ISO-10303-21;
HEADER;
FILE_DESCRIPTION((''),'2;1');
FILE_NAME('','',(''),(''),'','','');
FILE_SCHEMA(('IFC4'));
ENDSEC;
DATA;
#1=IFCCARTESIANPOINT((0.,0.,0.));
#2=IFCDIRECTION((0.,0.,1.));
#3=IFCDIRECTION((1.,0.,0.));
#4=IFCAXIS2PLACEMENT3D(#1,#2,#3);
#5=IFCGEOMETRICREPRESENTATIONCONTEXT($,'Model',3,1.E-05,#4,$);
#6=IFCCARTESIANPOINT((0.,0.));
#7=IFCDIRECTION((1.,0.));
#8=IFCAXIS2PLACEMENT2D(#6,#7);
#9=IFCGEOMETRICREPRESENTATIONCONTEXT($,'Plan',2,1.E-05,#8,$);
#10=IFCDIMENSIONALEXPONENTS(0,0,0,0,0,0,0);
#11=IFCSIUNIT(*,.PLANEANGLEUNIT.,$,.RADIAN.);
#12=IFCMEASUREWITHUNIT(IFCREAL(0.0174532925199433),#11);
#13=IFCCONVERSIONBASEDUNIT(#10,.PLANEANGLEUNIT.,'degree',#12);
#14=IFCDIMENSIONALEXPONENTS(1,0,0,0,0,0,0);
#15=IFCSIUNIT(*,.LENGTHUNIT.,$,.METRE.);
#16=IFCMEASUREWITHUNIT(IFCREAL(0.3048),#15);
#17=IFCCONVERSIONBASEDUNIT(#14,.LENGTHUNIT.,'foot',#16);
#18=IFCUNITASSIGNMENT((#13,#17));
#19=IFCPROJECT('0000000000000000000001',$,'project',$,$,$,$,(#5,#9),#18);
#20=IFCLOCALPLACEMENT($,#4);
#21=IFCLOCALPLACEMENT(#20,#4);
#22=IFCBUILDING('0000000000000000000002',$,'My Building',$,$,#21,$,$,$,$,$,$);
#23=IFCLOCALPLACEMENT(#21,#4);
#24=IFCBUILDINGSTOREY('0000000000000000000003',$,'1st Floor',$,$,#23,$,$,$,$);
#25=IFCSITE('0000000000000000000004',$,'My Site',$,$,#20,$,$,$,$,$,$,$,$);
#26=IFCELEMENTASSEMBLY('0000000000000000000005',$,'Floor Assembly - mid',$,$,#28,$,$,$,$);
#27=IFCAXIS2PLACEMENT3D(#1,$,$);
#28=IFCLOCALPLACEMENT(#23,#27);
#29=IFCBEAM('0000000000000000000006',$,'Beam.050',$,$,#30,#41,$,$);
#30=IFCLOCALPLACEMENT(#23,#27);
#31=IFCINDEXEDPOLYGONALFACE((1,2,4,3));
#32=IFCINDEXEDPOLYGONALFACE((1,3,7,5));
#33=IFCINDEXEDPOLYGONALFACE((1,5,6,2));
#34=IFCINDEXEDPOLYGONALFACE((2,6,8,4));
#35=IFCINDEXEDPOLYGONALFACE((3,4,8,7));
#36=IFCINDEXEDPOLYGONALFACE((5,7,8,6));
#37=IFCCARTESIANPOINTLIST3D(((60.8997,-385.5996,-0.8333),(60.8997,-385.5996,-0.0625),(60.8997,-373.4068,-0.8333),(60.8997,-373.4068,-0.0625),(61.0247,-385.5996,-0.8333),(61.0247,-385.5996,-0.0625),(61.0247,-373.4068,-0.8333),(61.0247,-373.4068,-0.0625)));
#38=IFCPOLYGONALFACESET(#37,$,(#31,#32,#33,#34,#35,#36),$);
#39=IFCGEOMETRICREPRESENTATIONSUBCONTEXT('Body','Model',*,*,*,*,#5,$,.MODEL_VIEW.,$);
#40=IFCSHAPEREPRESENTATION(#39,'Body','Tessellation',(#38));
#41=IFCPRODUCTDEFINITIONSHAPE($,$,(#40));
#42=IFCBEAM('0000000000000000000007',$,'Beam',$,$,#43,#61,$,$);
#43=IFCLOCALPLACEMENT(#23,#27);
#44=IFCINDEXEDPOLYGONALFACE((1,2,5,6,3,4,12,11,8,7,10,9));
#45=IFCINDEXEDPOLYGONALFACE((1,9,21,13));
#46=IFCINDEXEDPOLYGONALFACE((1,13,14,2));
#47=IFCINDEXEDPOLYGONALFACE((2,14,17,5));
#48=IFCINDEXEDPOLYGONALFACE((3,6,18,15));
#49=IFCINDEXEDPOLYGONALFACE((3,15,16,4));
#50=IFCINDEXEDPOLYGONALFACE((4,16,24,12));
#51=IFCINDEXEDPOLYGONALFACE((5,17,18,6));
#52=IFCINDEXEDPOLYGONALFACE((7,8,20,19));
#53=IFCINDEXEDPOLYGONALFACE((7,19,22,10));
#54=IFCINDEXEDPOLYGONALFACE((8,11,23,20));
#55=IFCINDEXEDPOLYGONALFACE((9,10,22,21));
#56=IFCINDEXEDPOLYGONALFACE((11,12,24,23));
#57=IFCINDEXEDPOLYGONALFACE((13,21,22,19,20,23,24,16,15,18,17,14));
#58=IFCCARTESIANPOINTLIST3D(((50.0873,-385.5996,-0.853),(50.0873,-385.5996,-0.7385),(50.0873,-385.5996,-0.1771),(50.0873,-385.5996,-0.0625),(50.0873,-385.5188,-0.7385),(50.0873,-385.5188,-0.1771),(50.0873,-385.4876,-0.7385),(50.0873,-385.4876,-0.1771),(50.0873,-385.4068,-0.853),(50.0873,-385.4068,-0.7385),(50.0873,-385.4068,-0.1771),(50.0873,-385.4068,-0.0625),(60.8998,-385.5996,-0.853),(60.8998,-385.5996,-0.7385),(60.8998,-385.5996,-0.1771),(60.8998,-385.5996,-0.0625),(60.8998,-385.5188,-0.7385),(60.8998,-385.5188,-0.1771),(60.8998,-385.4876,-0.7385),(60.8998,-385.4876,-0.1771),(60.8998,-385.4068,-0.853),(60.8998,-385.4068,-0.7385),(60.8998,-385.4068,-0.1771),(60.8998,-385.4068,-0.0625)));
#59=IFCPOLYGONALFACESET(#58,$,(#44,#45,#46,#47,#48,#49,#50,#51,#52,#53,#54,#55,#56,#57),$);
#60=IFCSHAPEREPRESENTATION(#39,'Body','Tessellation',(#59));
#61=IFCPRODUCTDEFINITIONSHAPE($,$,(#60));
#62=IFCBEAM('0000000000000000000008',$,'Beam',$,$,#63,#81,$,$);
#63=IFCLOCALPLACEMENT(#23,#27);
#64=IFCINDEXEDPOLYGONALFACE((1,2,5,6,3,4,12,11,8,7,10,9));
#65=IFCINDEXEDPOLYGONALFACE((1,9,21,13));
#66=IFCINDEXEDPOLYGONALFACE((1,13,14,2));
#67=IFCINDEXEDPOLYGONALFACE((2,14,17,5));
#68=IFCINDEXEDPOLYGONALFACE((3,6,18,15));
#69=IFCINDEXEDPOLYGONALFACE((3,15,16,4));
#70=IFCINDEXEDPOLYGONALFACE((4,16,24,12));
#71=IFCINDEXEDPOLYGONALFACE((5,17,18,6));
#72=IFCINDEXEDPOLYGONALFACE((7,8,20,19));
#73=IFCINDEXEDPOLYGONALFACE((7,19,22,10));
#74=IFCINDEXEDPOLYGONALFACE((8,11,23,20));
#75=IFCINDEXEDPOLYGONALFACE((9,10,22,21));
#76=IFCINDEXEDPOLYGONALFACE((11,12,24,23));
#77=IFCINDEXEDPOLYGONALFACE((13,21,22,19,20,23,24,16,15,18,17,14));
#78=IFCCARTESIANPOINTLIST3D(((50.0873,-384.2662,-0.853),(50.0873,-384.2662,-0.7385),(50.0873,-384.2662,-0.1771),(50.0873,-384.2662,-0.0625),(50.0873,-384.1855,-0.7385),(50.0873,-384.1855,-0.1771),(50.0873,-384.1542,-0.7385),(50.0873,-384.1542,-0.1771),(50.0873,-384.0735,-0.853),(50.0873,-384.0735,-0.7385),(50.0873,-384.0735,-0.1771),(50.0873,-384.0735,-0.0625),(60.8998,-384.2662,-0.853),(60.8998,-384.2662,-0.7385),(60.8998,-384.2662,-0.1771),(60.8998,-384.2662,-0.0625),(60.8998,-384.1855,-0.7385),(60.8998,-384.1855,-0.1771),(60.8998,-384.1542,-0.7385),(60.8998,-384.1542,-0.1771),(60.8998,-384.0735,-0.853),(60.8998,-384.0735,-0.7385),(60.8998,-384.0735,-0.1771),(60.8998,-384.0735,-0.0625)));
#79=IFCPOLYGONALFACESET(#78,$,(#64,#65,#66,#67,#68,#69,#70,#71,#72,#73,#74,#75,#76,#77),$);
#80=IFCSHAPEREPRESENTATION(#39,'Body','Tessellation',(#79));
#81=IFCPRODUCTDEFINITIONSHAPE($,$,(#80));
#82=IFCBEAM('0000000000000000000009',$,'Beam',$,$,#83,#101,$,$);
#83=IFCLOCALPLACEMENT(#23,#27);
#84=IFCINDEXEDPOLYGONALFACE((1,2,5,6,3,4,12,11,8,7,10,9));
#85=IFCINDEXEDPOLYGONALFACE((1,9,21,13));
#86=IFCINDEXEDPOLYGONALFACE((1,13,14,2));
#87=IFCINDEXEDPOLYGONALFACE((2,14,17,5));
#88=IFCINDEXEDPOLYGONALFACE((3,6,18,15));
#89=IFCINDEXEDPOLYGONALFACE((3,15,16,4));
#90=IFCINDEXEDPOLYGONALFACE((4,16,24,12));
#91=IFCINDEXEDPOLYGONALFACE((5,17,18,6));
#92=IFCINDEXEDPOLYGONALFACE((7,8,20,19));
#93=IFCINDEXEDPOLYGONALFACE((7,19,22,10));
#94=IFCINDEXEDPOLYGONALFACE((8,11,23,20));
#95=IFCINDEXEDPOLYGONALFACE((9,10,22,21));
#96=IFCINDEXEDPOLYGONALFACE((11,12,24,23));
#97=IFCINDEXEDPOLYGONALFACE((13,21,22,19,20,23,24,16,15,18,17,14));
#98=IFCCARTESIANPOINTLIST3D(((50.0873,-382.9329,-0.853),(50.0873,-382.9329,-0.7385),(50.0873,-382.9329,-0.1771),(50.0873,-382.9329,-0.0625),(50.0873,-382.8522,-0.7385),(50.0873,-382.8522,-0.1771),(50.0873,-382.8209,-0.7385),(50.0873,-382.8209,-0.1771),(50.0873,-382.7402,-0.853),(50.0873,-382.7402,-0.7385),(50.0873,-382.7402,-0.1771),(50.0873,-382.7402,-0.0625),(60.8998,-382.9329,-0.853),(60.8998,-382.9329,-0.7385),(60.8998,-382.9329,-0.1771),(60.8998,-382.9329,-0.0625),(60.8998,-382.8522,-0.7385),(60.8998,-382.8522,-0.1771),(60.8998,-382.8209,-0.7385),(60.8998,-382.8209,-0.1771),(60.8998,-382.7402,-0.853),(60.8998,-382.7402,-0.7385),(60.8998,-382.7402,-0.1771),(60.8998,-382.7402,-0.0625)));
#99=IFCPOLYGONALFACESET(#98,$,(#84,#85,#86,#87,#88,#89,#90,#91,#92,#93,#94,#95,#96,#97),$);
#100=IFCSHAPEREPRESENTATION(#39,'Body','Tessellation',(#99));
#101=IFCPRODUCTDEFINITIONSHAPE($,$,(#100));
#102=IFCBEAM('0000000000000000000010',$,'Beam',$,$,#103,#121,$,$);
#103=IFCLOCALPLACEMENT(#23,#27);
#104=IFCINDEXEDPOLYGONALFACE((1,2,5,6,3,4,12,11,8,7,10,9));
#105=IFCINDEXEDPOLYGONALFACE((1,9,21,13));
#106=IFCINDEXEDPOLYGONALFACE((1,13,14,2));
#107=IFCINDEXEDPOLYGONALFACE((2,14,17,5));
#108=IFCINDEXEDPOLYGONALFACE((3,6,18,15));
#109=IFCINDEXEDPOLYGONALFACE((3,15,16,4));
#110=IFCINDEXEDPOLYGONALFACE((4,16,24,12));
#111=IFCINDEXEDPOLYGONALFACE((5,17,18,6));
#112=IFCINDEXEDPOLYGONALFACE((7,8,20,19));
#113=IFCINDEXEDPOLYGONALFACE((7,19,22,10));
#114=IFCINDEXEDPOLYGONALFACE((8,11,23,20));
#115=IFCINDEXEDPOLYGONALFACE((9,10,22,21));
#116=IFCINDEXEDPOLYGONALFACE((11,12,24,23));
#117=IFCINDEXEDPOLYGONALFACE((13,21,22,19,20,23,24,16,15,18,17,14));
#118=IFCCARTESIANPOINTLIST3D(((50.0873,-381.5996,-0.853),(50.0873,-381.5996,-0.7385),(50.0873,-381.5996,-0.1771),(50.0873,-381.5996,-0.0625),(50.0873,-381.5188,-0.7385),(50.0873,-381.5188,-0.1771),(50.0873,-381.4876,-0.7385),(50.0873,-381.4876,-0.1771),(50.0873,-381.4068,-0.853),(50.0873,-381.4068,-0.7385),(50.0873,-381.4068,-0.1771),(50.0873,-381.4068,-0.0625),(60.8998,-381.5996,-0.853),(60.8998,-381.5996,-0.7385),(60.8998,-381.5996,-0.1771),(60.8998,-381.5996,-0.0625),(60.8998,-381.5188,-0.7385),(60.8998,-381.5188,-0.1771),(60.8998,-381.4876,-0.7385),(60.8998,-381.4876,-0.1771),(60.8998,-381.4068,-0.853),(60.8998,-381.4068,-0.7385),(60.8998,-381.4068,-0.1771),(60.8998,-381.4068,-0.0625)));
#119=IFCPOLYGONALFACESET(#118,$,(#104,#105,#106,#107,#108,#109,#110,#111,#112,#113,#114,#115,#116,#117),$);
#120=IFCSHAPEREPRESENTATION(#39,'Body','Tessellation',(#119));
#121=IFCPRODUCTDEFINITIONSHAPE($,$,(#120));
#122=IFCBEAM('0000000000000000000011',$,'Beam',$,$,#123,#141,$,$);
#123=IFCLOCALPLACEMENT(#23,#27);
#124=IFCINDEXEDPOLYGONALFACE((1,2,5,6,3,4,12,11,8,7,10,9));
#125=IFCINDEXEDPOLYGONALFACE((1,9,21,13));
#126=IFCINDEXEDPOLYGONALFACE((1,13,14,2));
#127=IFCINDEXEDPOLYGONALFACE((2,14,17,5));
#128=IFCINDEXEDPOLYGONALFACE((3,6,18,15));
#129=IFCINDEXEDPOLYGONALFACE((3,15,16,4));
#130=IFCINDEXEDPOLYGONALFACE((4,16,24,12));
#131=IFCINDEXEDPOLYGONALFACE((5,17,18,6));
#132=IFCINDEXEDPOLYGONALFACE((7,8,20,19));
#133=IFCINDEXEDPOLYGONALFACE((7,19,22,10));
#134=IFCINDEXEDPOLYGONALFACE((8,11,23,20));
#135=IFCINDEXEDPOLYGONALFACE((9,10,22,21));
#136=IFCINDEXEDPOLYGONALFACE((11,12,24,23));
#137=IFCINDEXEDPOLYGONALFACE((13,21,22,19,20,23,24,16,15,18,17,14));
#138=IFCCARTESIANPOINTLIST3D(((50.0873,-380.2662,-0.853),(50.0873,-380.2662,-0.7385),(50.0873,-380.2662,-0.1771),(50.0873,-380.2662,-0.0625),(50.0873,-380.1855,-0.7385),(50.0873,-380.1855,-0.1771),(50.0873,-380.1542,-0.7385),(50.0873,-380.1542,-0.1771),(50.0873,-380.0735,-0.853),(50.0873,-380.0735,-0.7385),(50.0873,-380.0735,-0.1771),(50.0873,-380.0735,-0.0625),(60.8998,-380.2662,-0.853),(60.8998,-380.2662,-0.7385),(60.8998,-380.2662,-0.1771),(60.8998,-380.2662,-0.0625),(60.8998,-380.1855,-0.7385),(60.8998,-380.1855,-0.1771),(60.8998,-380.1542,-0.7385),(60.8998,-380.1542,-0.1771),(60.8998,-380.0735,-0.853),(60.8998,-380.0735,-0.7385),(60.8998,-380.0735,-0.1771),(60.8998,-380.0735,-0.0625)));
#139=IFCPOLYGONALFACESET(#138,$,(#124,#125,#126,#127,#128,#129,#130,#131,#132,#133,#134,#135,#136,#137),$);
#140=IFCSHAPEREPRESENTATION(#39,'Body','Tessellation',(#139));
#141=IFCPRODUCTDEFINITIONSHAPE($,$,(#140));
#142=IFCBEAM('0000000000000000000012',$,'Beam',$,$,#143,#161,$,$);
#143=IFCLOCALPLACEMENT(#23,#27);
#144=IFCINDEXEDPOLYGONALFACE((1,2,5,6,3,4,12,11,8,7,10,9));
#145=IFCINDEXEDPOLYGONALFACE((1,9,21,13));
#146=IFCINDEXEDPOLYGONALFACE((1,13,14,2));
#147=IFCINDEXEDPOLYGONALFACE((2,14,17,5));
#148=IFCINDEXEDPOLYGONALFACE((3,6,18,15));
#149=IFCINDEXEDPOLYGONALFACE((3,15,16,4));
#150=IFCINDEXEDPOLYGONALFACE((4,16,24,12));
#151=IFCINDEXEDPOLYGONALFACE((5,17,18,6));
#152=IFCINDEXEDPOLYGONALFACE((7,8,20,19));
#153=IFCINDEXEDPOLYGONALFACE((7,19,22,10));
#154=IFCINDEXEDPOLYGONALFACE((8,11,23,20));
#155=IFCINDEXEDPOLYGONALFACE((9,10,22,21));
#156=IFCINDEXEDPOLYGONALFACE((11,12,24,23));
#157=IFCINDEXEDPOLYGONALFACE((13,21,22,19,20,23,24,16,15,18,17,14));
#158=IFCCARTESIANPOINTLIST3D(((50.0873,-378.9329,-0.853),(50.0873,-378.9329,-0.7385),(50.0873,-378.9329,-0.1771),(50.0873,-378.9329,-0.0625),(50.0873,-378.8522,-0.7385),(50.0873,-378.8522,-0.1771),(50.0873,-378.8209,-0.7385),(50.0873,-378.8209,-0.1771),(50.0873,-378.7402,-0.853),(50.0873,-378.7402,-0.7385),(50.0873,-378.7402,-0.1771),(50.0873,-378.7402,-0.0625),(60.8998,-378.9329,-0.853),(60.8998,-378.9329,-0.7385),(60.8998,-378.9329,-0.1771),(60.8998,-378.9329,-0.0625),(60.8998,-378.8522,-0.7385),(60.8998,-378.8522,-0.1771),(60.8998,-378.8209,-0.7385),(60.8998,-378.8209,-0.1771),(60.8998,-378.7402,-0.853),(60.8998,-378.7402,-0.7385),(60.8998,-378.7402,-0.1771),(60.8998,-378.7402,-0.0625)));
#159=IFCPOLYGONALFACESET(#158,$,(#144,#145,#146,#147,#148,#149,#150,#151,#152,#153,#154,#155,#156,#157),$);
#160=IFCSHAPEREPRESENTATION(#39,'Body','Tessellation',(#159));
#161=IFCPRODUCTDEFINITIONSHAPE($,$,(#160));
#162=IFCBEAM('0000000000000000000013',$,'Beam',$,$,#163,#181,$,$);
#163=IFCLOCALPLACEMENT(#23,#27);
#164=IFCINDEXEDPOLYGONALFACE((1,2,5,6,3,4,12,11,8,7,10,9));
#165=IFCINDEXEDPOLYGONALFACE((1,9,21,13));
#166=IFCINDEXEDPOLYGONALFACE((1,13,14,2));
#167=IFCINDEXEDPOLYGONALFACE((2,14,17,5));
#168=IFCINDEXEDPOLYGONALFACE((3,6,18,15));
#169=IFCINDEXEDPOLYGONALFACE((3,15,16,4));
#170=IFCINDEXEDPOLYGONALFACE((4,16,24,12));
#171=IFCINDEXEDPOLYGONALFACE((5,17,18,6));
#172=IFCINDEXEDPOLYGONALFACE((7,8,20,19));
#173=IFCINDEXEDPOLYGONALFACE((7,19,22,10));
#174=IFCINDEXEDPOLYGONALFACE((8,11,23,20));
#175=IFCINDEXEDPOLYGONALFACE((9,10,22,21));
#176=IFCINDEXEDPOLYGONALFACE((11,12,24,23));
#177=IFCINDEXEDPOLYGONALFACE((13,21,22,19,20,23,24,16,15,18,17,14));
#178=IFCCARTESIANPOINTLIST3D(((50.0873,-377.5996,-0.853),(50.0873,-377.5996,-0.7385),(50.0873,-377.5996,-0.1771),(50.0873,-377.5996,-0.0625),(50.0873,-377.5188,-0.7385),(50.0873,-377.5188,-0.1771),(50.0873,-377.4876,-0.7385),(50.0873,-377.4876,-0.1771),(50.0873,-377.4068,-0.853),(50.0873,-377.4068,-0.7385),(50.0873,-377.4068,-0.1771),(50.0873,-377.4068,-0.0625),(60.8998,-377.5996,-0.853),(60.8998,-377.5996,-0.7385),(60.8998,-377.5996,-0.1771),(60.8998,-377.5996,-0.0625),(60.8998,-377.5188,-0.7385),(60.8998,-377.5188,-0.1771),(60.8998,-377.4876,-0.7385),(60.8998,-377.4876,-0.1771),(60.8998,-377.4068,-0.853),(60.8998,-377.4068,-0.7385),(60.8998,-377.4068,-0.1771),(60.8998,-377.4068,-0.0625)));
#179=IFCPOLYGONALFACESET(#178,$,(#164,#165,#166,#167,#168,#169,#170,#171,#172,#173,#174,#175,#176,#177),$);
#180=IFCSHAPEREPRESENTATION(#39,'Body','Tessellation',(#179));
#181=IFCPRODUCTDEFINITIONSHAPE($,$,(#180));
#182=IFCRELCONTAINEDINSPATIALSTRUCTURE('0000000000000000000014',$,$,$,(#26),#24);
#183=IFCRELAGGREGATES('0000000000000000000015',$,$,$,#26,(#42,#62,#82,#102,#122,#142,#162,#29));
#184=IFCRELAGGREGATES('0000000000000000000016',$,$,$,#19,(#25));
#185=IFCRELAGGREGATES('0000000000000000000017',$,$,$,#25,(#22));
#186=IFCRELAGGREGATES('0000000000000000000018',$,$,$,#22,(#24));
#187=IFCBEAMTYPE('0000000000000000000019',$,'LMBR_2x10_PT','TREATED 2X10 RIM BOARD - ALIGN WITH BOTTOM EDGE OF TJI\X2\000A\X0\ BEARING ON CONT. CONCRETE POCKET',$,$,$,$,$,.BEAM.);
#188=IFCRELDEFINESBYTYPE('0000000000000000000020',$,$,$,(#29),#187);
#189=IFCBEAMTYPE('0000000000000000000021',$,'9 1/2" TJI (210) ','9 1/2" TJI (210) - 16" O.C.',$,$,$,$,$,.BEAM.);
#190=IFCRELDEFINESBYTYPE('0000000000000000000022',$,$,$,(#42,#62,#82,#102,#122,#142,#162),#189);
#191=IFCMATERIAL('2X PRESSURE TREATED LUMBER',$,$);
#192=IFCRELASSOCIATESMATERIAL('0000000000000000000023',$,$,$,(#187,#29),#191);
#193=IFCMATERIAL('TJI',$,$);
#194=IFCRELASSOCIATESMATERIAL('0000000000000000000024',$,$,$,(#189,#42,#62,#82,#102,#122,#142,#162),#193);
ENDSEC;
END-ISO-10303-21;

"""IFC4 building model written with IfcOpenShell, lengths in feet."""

from ifc_helpers import new_model, entity, si_unit, converted_unit, frame, origin_with_axes, origin_2d_with_axis, place, context, subcontext, project, spatial, indexed_curve, outline, extrude, material, material_profile, profile_set, profile_usage, type_object, element, aggregate, save


model = new_model("IFC4")

# Units and contexts
model_context = context("Model", 3, precision=1e-05, world=origin_with_axes())
plan_context = context("Plan", 2, precision=1e-05, world=origin_2d_with_axis())
body_context = subcontext(model_context, "Body", "Model", "MODEL_VIEW")
ifc_project = project(units=[converted_unit("PLANEANGLEUNIT", "degree", entity("IfcReal", 0.0174532925199433), si_unit("PLANEANGLEUNIT", "RADIAN"), dimensions=[0, 0, 0, 0, 0, 0, 0]), converted_unit("LENGTHUNIT", "foot", entity("IfcReal", 0.3048), si_unit("LENGTHUNIT", "METRE"), dimensions=[1, 0, 0, 0, 0, 0, 0])], contexts=[model_context, plan_context])

# Site, building, storey
site_placement = place(None, origin_with_axes())
site = spatial("IfcSite", under=ifc_project, at=site_placement, Name="My Site")
building_placement = place(site_placement, origin_with_axes())
building = spatial("IfcBuilding", under=site, at=building_placement, Name="My Building")
storey_placement = place(building_placement, origin_with_axes())
storey = spatial("IfcBuildingStorey", under=building, at=storey_placement, Name="1st Floor")

# Element assembly, beams
assembly_1_placement = place(storey_placement, frame((50.0352, -373.4068, -0.0625), z_axis=(0.0, 0.0, 1.0), x_axis=(1.0, 0.0, 0.0)))
assembly_1 = element("IfcElementAssembly", 1, at=assembly_1_placement, inside=storey, Name="Floor Assembly - mid")
ifc_material_1 = material(Name="2X PRESSURE TREATED LUMBER")
ifc_material_profile_1 = material_profile(ifc_material_1, outline(indexed_curve([(-0.0625, 0.3854), (0.0625, 0.3854), (0.0625, -0.3854), (-0.0625, -0.3854), (-0.0625, 0.3854)])))
ifc_profile_set_1 = profile_set([ifc_material_profile_1])
ifc_profile_usage_1 = profile_usage(ifc_profile_set_1, cardinal=5)
beam_type_1 = type_object("IfcBeamType", Name="LMBR_2x10_PT", Description="TREATED 2X10 RIM BOARD - ALIGN WITH BOTTOM EDGE OF TJI\n BEARING ON CONT. CONCRETE POCKET", PredefinedType="BEAM", material=ifc_profile_set_1)
beam_1_placement = place(assembly_1_placement, frame((10.927, 0.0, -0.3854), z_axis=(0.000001, -1.0, 0.0), x_axis=(1.0, 0.000001, 0.0)))
beam_1 = element("IfcBeam", 2, at=beam_1_placement, type_object=beam_type_1, material=ifc_profile_usage_1, Name="Beam.050", context=body_context, shape_type="SweptSolid", body=[
    extrude(outline(indexed_curve([(-0.0625, 0.3854), (0.0625, 0.3854), (0.0625, -0.3854), (-0.0625, -0.3854), (-0.0625, 0.3854)])), origin_with_axes(), (0.0, 0.0, 1.0), 12.1927),
])
ifc_material_2 = material(Name="TJI")
ifc_material_profile_2 = material_profile(ifc_material_2, outline(indexed_curve([(0.0964, 0.7905), (-0.0964, 0.7905), (-0.0964, 0.6759), (-0.0156, 0.6759), (-0.0156, 0.1146), (-0.0964, 0.1146), (-0.0964, 0.0), (0.0964, 0.0), (0.0964, 0.1146), (0.0156, 0.1146), (0.0157, 0.6759), (0.0964, 0.6759), (0.0964, 0.7905)])))
ifc_profile_set_2 = profile_set([ifc_material_profile_2])
ifc_profile_usage_2 = profile_usage(ifc_profile_set_2, cardinal=5)
beam_type_2 = type_object("IfcBeamType", Name="9 1/2\" TJI (210) ", Description="9 1/2\" TJI (210) - 16\" O.C.", PredefinedType="BEAM", material=ifc_profile_set_2)
beam_2_placement = place(assembly_1_placement, frame((0.0521, -12.0964, -0.7905), z_axis=(1.0, 0.0, 0.0), x_axis=(0.0, 1.0, 0.0)))
beam_2 = element("IfcBeam", 3, at=beam_2_placement, type_object=beam_type_2, material=ifc_profile_usage_2, Name="Beam", context=body_context, shape_type="SweptSolid", body=[
    extrude(outline(indexed_curve([(0.0964, 0.7905), (-0.0964, 0.7905), (-0.0964, 0.6759), (-0.0156, 0.6759), (-0.0156, 0.1146), (-0.0964, 0.1146), (-0.0964, 0.0), (0.0964, 0.0), (0.0964, 0.1146), (0.0156, 0.1146), (0.0157, 0.6759), (0.0964, 0.6759), (0.0964, 0.7905)])), origin_with_axes(), (0.0, 0.0, 1.0), 10.8125),
])
ifc_profile_usage_3 = profile_usage(ifc_profile_set_2, cardinal=5)
beam_3_placement = place(assembly_1_placement, frame((0.0521, -10.763, -0.7905), z_axis=(1.0, 0.0, 0.0), x_axis=(0.0, 1.0, 0.0)))
beam_3 = element("IfcBeam", 4, at=beam_3_placement, type_object=beam_type_2, material=ifc_profile_usage_3, Name="Beam", context=body_context, shape_type="SweptSolid", body=[
    extrude(outline(indexed_curve([(0.0964, 0.7905), (-0.0964, 0.7905), (-0.0964, 0.6759), (-0.0156, 0.6759), (-0.0156, 0.1146), (-0.0964, 0.1146), (-0.0964, 0.0), (0.0964, 0.0), (0.0964, 0.1146), (0.0156, 0.1146), (0.0157, 0.6759), (0.0964, 0.6759), (0.0964, 0.7905)])), origin_with_axes(), (0.0, 0.0, 1.0), 10.8125),
])
ifc_profile_usage_4 = profile_usage(ifc_profile_set_2, cardinal=5)
beam_4_placement = place(assembly_1_placement, frame((0.0521, -9.4297, -0.7905), z_axis=(1.0, 0.0, 0.0), x_axis=(0.0, 1.0, 0.0)))
beam_4 = element("IfcBeam", 5, at=beam_4_placement, type_object=beam_type_2, material=ifc_profile_usage_4, Name="Beam", context=body_context, shape_type="SweptSolid", body=[
    extrude(outline(indexed_curve([(0.0964, 0.7905), (-0.0964, 0.7905), (-0.0964, 0.6759), (-0.0156, 0.6759), (-0.0156, 0.1146), (-0.0964, 0.1146), (-0.0964, 0.0), (0.0964, 0.0), (0.0964, 0.1146), (0.0156, 0.1146), (0.0157, 0.6759), (0.0964, 0.6759), (0.0964, 0.7905)])), origin_with_axes(), (0.0, 0.0, 1.0), 10.8125),
])
ifc_profile_usage_5 = profile_usage(ifc_profile_set_2, cardinal=5)
beam_5_placement = place(assembly_1_placement, frame((0.0521, -8.0964, -0.7905), z_axis=(1.0, 0.0, 0.0), x_axis=(0.0, 1.0, 0.0)))
beam_5 = element("IfcBeam", 6, at=beam_5_placement, type_object=beam_type_2, material=ifc_profile_usage_5, Name="Beam", context=body_context, shape_type="SweptSolid", body=[
    extrude(outline(indexed_curve([(0.0964, 0.7905), (-0.0964, 0.7905), (-0.0964, 0.6759), (-0.0156, 0.6759), (-0.0156, 0.1146), (-0.0964, 0.1146), (-0.0964, 0.0), (0.0964, 0.0), (0.0964, 0.1146), (0.0156, 0.1146), (0.0157, 0.6759), (0.0964, 0.6759), (0.0964, 0.7905)])), origin_with_axes(), (0.0, 0.0, 1.0), 10.8125),
])
ifc_profile_usage_6 = profile_usage(ifc_profile_set_2, cardinal=5)
beam_6_placement = place(assembly_1_placement, frame((0.0521, -6.763, -0.7905), z_axis=(1.0, 0.0, 0.0), x_axis=(0.0, 1.0, 0.0)))
beam_6 = element("IfcBeam", 7, at=beam_6_placement, type_object=beam_type_2, material=ifc_profile_usage_6, Name="Beam", context=body_context, shape_type="SweptSolid", body=[
    extrude(outline(indexed_curve([(0.0964, 0.7905), (-0.0964, 0.7905), (-0.0964, 0.6759), (-0.0156, 0.6759), (-0.0156, 0.1146), (-0.0964, 0.1146), (-0.0964, 0.0), (0.0964, 0.0), (0.0964, 0.1146), (0.0156, 0.1146), (0.0157, 0.6759), (0.0964, 0.6759), (0.0964, 0.7905)])), origin_with_axes(), (0.0, 0.0, 1.0), 10.8125),
])
ifc_profile_usage_7 = profile_usage(ifc_profile_set_2, cardinal=5)
beam_7_placement = place(assembly_1_placement, frame((0.0521, -5.4297, -0.7905), z_axis=(1.0, 0.0, 0.0), x_axis=(0.0, 1.0, 0.0)))
beam_7 = element("IfcBeam", 8, at=beam_7_placement, type_object=beam_type_2, material=ifc_profile_usage_7, Name="Beam", context=body_context, shape_type="SweptSolid", body=[
    extrude(outline(indexed_curve([(0.0964, 0.7905), (-0.0964, 0.7905), (-0.0964, 0.6759), (-0.0156, 0.6759), (-0.0156, 0.1146), (-0.0964, 0.1146), (-0.0964, 0.0), (0.0964, 0.0), (0.0964, 0.1146), (0.0156, 0.1146), (0.0157, 0.6759), (0.0964, 0.6759), (0.0964, 0.7905)])), origin_with_axes(), (0.0, 0.0, 1.0), 10.8125),
])
ifc_profile_usage_8 = profile_usage(ifc_profile_set_2, cardinal=5)
beam_8_placement = place(assembly_1_placement, frame((0.0521, -4.0964, -0.7905), z_axis=(1.0, 0.0, 0.0), x_axis=(0.0, 1.0, 0.0)))
beam_8 = element("IfcBeam", 9, at=beam_8_placement, type_object=beam_type_2, material=ifc_profile_usage_8, Name="Beam", context=body_context, shape_type="SweptSolid", body=[
    extrude(outline(indexed_curve([(0.0964, 0.7905), (-0.0964, 0.7905), (-0.0964, 0.6759), (-0.0156, 0.6759), (-0.0156, 0.1146), (-0.0964, 0.1146), (-0.0964, 0.0), (0.0964, 0.0), (0.0964, 0.1146), (0.0156, 0.1146), (0.0157, 0.6759), (0.0964, 0.6759), (0.0964, 0.7905)])), origin_with_axes(), (0.0, 0.0, 1.0), 10.8125),
])

aggregate(assembly_1, [beam_2, beam_3, beam_4, beam_5, beam_6, beam_7, beam_8, beam_1])

save(model, "model.ifc")
